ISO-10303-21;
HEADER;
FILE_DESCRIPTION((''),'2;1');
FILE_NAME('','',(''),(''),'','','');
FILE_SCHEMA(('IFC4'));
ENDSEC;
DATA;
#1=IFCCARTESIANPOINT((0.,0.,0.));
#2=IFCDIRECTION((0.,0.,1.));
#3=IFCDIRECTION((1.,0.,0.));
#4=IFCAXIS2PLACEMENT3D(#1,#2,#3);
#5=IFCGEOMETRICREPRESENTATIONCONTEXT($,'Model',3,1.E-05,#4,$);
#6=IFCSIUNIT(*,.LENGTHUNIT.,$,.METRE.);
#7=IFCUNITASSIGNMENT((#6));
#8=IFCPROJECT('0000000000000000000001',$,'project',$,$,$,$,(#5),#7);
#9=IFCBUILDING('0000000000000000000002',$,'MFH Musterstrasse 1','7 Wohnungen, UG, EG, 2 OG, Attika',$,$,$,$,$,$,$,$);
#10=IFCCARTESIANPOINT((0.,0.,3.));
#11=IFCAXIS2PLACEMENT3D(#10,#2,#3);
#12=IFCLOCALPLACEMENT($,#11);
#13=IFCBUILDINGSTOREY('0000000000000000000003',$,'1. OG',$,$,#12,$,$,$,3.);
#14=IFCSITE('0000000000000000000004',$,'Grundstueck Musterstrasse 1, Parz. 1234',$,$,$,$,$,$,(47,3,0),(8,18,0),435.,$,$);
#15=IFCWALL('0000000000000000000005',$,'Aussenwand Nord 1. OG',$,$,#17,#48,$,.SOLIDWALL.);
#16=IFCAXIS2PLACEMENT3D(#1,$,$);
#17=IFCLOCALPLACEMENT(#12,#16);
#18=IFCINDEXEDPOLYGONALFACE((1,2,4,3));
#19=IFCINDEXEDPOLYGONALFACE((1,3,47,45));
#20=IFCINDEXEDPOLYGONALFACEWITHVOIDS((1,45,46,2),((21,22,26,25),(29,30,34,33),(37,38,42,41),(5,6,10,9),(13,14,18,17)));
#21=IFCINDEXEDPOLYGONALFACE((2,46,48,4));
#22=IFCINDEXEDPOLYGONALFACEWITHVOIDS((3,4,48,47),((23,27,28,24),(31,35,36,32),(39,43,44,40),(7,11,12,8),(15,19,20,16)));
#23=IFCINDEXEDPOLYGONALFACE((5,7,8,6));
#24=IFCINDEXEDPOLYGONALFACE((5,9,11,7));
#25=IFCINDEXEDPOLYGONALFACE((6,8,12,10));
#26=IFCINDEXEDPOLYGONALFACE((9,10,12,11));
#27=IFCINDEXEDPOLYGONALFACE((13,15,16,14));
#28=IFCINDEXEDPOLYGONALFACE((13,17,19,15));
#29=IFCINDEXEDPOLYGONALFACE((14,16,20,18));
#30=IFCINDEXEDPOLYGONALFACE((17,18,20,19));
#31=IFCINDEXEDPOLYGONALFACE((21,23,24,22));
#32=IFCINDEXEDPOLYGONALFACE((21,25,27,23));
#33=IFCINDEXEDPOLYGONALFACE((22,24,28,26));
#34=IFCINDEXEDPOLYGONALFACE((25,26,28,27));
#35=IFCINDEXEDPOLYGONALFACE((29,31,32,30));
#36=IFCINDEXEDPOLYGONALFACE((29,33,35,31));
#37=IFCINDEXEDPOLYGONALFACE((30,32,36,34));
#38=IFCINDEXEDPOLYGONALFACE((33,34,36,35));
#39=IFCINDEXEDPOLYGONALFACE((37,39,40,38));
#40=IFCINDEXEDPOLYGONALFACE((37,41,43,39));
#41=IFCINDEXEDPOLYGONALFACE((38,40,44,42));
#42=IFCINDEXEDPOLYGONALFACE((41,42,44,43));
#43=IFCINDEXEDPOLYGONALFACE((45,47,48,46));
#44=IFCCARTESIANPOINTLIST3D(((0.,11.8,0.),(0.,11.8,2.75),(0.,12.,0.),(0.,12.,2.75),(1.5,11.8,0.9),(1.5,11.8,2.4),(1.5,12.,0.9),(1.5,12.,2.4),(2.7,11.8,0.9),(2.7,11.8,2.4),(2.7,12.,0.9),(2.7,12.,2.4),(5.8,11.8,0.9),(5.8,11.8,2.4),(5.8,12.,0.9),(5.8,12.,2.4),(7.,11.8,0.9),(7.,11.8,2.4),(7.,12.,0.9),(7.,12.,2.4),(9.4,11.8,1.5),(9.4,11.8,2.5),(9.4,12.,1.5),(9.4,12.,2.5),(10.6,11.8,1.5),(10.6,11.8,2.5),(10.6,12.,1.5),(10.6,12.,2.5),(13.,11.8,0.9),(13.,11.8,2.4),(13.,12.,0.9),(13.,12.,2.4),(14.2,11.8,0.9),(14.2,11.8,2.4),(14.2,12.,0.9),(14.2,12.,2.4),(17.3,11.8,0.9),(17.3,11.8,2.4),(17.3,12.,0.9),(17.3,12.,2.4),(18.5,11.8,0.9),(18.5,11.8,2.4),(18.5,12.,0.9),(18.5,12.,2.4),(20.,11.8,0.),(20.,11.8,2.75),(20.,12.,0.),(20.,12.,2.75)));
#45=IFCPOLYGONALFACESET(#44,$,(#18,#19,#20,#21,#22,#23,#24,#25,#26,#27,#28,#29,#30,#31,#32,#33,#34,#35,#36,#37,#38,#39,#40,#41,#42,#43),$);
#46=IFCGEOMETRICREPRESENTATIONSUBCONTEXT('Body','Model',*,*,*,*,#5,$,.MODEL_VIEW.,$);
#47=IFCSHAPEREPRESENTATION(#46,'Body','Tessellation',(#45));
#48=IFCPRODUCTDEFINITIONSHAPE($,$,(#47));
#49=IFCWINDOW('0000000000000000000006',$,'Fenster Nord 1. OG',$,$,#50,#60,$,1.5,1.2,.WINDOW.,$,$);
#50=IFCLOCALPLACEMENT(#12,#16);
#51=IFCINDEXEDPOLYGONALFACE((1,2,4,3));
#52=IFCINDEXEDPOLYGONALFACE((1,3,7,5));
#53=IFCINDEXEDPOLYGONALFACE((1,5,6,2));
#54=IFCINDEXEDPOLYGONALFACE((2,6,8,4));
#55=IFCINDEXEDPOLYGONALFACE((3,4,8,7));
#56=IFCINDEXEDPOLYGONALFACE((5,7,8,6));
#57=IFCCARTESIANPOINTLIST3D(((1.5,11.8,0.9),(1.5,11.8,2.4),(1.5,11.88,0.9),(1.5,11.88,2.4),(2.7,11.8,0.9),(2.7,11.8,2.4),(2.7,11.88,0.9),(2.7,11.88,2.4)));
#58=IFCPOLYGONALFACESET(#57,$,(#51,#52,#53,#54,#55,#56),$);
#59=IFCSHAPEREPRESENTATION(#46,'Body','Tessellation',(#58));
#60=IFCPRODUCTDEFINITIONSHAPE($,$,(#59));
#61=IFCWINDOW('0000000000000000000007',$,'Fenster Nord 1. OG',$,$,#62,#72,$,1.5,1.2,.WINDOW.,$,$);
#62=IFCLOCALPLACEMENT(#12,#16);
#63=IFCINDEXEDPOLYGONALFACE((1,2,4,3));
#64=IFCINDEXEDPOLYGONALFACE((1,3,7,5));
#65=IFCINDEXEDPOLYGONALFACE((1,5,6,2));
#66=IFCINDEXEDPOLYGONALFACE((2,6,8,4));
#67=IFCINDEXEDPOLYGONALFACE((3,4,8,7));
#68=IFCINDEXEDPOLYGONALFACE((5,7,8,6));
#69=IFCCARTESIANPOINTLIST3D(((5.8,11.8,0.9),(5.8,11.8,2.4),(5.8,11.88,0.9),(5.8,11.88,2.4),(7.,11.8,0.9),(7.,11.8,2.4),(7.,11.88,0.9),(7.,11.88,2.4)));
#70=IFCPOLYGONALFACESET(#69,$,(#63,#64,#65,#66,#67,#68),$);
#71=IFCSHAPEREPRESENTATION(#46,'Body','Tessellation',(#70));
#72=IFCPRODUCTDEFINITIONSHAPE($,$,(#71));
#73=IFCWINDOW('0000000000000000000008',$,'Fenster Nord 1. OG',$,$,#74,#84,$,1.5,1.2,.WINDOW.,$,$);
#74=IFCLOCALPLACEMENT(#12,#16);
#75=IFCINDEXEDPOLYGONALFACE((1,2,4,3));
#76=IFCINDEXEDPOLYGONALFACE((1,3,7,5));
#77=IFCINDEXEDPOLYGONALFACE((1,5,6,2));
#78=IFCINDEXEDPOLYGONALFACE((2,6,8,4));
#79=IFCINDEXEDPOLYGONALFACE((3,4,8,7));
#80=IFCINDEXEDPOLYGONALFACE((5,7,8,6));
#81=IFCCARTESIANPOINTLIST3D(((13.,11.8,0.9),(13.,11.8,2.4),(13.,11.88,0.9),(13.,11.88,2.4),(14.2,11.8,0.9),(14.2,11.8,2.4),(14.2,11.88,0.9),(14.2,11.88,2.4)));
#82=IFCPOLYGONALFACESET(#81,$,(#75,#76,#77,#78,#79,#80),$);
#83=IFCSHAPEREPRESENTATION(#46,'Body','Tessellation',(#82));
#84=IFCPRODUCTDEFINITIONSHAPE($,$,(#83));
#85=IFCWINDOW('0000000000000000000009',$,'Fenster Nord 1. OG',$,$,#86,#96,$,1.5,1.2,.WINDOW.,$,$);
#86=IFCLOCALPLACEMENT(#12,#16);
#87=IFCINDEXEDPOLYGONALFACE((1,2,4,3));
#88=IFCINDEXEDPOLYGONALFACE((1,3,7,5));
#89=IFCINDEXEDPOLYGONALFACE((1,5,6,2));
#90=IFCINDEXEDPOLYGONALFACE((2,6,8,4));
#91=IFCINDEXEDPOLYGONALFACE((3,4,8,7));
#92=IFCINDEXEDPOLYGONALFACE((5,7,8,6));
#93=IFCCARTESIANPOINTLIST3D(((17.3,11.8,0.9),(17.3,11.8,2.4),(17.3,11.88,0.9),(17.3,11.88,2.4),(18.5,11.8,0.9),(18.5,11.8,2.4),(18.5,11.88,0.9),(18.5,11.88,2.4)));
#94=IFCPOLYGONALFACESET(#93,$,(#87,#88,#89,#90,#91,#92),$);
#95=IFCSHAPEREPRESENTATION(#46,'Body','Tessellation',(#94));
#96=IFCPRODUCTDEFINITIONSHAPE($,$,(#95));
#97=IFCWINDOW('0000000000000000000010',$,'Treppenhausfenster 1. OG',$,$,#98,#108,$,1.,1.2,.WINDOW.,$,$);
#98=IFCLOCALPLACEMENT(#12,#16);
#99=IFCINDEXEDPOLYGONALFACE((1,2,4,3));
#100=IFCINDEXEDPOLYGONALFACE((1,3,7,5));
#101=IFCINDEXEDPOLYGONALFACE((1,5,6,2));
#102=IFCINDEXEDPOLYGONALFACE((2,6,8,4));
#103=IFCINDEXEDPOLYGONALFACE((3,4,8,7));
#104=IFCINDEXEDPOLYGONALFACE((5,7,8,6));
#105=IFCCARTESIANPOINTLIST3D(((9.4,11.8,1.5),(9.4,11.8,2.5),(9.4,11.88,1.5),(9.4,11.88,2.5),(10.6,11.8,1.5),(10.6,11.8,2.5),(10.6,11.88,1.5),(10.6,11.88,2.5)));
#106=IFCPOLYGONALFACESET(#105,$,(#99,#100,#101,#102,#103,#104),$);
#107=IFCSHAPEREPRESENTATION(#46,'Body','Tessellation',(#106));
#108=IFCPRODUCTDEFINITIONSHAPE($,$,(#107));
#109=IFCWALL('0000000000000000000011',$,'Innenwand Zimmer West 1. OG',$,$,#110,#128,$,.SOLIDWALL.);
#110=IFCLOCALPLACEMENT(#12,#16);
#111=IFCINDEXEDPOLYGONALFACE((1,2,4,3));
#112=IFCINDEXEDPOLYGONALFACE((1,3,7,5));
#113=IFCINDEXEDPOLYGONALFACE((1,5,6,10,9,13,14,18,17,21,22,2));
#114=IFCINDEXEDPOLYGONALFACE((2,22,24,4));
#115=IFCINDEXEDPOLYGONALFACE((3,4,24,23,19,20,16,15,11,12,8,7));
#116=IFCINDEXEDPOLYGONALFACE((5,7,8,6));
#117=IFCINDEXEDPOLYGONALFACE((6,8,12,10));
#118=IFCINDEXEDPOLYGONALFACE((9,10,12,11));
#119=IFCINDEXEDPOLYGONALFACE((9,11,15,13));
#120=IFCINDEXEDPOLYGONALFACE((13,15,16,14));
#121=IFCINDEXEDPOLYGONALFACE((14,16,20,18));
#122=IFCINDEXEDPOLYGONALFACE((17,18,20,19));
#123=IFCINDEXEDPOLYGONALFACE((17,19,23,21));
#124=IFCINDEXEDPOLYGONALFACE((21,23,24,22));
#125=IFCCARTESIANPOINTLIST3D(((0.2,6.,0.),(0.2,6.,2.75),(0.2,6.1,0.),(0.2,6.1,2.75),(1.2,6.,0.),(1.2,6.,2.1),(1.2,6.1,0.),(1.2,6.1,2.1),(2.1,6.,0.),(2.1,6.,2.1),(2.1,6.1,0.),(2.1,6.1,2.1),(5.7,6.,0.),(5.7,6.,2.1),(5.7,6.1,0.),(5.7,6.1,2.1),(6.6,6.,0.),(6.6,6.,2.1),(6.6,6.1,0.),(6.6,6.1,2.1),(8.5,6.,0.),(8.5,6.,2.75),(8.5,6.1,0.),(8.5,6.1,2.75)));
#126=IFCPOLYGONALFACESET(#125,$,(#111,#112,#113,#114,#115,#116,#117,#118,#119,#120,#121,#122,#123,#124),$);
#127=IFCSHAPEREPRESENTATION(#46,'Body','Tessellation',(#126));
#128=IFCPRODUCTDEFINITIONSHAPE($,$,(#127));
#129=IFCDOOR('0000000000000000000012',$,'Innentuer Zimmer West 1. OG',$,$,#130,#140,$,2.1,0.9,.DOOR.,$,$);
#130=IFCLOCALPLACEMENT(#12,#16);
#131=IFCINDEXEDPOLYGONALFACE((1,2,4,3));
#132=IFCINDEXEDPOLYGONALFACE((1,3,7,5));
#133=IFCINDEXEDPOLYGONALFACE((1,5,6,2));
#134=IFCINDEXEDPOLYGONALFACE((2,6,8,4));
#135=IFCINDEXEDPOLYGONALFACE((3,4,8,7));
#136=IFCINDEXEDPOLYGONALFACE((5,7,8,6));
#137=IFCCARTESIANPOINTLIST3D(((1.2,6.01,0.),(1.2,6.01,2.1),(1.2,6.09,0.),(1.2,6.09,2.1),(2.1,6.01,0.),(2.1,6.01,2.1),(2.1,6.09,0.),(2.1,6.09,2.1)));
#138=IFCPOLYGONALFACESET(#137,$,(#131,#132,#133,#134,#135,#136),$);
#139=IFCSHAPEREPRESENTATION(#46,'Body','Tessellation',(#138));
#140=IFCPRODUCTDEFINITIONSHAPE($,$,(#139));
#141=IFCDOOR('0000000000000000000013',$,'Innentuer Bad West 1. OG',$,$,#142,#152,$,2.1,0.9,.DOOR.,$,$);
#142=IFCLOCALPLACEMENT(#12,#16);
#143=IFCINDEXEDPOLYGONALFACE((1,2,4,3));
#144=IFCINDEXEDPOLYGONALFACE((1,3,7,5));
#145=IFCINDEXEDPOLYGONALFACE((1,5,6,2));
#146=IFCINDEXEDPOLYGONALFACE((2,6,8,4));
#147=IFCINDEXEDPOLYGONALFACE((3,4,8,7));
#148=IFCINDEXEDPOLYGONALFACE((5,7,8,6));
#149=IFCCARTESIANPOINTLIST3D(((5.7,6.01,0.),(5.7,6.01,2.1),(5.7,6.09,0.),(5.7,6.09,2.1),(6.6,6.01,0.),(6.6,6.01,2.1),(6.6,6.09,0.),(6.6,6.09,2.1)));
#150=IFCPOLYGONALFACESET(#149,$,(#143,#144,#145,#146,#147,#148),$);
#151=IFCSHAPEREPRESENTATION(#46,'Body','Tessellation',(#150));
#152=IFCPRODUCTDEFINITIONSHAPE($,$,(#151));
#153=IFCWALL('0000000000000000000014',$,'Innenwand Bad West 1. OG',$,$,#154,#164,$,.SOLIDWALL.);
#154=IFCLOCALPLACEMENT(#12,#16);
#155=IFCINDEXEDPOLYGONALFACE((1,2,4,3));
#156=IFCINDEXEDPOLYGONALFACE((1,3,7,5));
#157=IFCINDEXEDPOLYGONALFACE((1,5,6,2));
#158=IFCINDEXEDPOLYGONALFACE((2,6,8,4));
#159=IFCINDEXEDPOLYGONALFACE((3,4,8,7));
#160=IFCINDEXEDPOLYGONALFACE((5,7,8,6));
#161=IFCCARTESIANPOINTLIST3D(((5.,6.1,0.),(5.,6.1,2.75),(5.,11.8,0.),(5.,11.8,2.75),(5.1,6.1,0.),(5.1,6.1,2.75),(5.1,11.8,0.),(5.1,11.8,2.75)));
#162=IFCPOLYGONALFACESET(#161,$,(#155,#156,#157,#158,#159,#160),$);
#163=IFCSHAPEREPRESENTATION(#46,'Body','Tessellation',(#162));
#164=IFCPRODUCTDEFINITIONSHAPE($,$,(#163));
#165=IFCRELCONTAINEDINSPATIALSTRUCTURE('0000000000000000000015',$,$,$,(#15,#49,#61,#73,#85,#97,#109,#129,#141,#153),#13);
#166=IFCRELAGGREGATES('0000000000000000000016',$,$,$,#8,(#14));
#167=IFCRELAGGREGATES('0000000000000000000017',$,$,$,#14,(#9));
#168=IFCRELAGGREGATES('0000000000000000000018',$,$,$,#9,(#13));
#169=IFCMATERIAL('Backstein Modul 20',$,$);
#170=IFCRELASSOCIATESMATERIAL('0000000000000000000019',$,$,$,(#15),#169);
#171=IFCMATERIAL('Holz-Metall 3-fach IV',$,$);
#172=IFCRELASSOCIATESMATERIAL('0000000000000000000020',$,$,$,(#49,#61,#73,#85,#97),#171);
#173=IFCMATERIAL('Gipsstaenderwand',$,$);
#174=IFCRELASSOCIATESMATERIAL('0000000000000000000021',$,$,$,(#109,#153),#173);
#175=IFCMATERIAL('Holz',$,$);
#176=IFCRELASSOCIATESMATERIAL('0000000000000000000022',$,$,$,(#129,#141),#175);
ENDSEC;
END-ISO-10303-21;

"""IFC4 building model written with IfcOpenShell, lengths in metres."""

from ifc_helpers import new_model, si_unit, frame, frame_2d, origin_with_axes, place, context, subcontext, project, spatial, rectangle, extrude, material, element, fill, save


model = new_model("IFC4")

# Units and contexts
model_context = context("Model", 3, precision=1e-05, world=origin_with_axes())
body_context = subcontext(model_context, "Body", "Model", "MODEL_VIEW")
ifc_project = project(units=[si_unit("LENGTHUNIT", "METRE")], contexts=[model_context])

# Site, building, storey
site = spatial("IfcSite", under=ifc_project, Name="Grundstueck Musterstrasse 1, Parz. 1234", RefLatitude=(47, 3, 0), RefLongitude=(8, 18, 0), RefElevation=435.0)
building = spatial("IfcBuilding", under=site, Name="MFH Musterstrasse 1", Description="7 Wohnungen, UG, EG, 2 OG, Attika")
storey_placement = place(None, frame((0.0, 0.0, 3.0), z_axis=(0.0, 0.0, 1.0), x_axis=(1.0, 0.0, 0.0)))
storey = spatial("IfcBuildingStorey", under=building, at=storey_placement, Name="1. OG", Elevation=3.0)

# Wall, openings, windows
ifc_material_1 = material(Name="Backstein Modul 20")
wall_1_placement = place(storey_placement, frame((0.0, 11.8, 0.0), z_axis=(0.0, 0.0, 1.0), x_axis=(1.0, 0.0, 0.0)))
wall_1 = element("IfcWall", 1, at=wall_1_placement, inside=storey, material=ifc_material_1, Name="Aussenwand Nord 1. OG", PredefinedType="SOLIDWALL", context=body_context, shape_type="SweptSolid", body=[
    extrude(rectangle(XDim=20.0, YDim=0.2, at=frame_2d((10.0, 0.1))), origin_with_axes(), (0.0, 0.0, 1.0), 2.75),
])
opening_1_placement = place(wall_1_placement, frame((1.5, -0.01, 0.9), z_axis=(0.0, 0.0, 1.0), x_axis=(1.0, 0.0, 0.0)))
opening_1 = element("IfcOpeningElement", 2, at=opening_1_placement, cuts=wall_1, context=body_context, shape_type="SweptSolid", body=[
    extrude(rectangle(XDim=1.2, YDim=0.42, at=frame_2d((0.6, 0.21))), origin_with_axes(), (0.0, 0.0, 1.0), 1.5),
])
opening_2_placement = place(wall_1_placement, frame((5.8, -0.01, 0.9), z_axis=(0.0, 0.0, 1.0), x_axis=(1.0, 0.0, 0.0)))
opening_2 = element("IfcOpeningElement", 3, at=opening_2_placement, cuts=wall_1, context=body_context, shape_type="SweptSolid", body=[
    extrude(rectangle(XDim=1.2, YDim=0.42, at=frame_2d((0.6, 0.21))), origin_with_axes(), (0.0, 0.0, 1.0), 1.5),
])
opening_3_placement = place(wall_1_placement, frame((13.0, -0.01, 0.9), z_axis=(0.0, 0.0, 1.0), x_axis=(1.0, 0.0, 0.0)))
opening_3 = element("IfcOpeningElement", 4, at=opening_3_placement, cuts=wall_1, context=body_context, shape_type="SweptSolid", body=[
    extrude(rectangle(XDim=1.2, YDim=0.42, at=frame_2d((0.6, 0.21))), origin_with_axes(), (0.0, 0.0, 1.0), 1.5),
])
opening_4_placement = place(wall_1_placement, frame((17.3, -0.01, 0.9), z_axis=(0.0, 0.0, 1.0), x_axis=(1.0, 0.0, 0.0)))
opening_4 = element("IfcOpeningElement", 5, at=opening_4_placement, cuts=wall_1, context=body_context, shape_type="SweptSolid", body=[
    extrude(rectangle(XDim=1.2, YDim=0.42, at=frame_2d((0.6, 0.21))), origin_with_axes(), (0.0, 0.0, 1.0), 1.5),
])
opening_5_placement = place(wall_1_placement, frame((9.4, -0.01, 1.5), z_axis=(0.0, 0.0, 1.0), x_axis=(1.0, 0.0, 0.0)))
opening_5 = element("IfcOpeningElement", 6, at=opening_5_placement, cuts=wall_1, context=body_context, shape_type="SweptSolid", body=[
    extrude(rectangle(XDim=1.2, YDim=0.42, at=frame_2d((0.6, 0.21))), origin_with_axes(), (0.0, 0.0, 1.0), 1.0),
])
ifc_material_2 = material(Name="Holz-Metall 3-fach IV")
window_1_placement = place(storey_placement, frame((1.5, 11.8, 0.9), z_axis=(0.0, 0.0, 1.0), x_axis=(1.0, 0.0, 0.0)))
window_1 = element("IfcWindow", 7, at=window_1_placement, inside=storey, material=ifc_material_2, Name="Fenster Nord 1. OG", OverallHeight=1.5, OverallWidth=1.2, PredefinedType="WINDOW", context=body_context, shape_type="SweptSolid", body=[
    extrude(rectangle(XDim=1.2, YDim=0.08, at=frame_2d((0.6, 0.04))), origin_with_axes(), (0.0, 0.0, 1.0), 1.5),
])
fill(opening_1, window_1)
window_2_placement = place(storey_placement, frame((5.8, 11.8, 0.9), z_axis=(0.0, 0.0, 1.0), x_axis=(1.0, 0.0, 0.0)))
window_2 = element("IfcWindow", 8, at=window_2_placement, inside=storey, material=ifc_material_2, Name="Fenster Nord 1. OG", OverallHeight=1.5, OverallWidth=1.2, PredefinedType="WINDOW", context=body_context, shape_type="SweptSolid", body=[
    extrude(rectangle(XDim=1.2, YDim=0.08, at=frame_2d((0.6, 0.04))), origin_with_axes(), (0.0, 0.0, 1.0), 1.5),
])
fill(opening_2, window_2)
window_3_placement = place(storey_placement, frame((13.0, 11.8, 0.9), z_axis=(0.0, 0.0, 1.0), x_axis=(1.0, 0.0, 0.0)))
window_3 = element("IfcWindow", 9, at=window_3_placement, inside=storey, material=ifc_material_2, Name="Fenster Nord 1. OG", OverallHeight=1.5, OverallWidth=1.2, PredefinedType="WINDOW", context=body_context, shape_type="SweptSolid", body=[
    extrude(rectangle(XDim=1.2, YDim=0.08, at=frame_2d((0.6, 0.04))), origin_with_axes(), (0.0, 0.0, 1.0), 1.5),
])
fill(opening_3, window_3)
window_4_placement = place(storey_placement, frame((17.3, 11.8, 0.9), z_axis=(0.0, 0.0, 1.0), x_axis=(1.0, 0.0, 0.0)))
window_4 = element("IfcWindow", 10, at=window_4_placement, inside=storey, material=ifc_material_2, Name="Fenster Nord 1. OG", OverallHeight=1.5, OverallWidth=1.2, PredefinedType="WINDOW", context=body_context, shape_type="SweptSolid", body=[
    extrude(rectangle(XDim=1.2, YDim=0.08, at=frame_2d((0.6, 0.04))), origin_with_axes(), (0.0, 0.0, 1.0), 1.5),
])
fill(opening_4, window_4)
window_5_placement = place(storey_placement, frame((9.4, 11.8, 1.5), z_axis=(0.0, 0.0, 1.0), x_axis=(1.0, 0.0, 0.0)))
window_5 = element("IfcWindow", 11, at=window_5_placement, inside=storey, material=ifc_material_2, Name="Treppenhausfenster 1. OG", OverallHeight=1.0, OverallWidth=1.2, PredefinedType="WINDOW", context=body_context, shape_type="SweptSolid", body=[
    extrude(rectangle(XDim=1.2, YDim=0.08, at=frame_2d((0.6, 0.04))), origin_with_axes(), (0.0, 0.0, 1.0), 1.0),
])
fill(opening_5, window_5)

# Wall, openings, doors
ifc_material_3 = material(Name="Gipsstaenderwand")
wall_2_placement = place(storey_placement, frame((0.2, 6.0, 0.0), z_axis=(0.0, 0.0, 1.0), x_axis=(1.0, 0.0, 0.0)))
wall_2 = element("IfcWall", 12, at=wall_2_placement, inside=storey, material=ifc_material_3, Name="Innenwand Zimmer West 1. OG", PredefinedType="SOLIDWALL", context=body_context, shape_type="SweptSolid", body=[
    extrude(rectangle(XDim=8.3, YDim=0.1, at=frame_2d((4.15, 0.05))), origin_with_axes(), (0.0, 0.0, 1.0), 2.75),
])
opening_6_placement = place(wall_2_placement, frame((1.0, -0.01, 0.0), z_axis=(0.0, 0.0, 1.0), x_axis=(1.0, 0.0, 0.0)))
opening_6 = element("IfcOpeningElement", 13, at=opening_6_placement, cuts=wall_2, context=body_context, shape_type="SweptSolid", body=[
    extrude(rectangle(XDim=0.9, YDim=0.12, at=frame_2d((0.45, 0.06))), origin_with_axes(), (0.0, 0.0, 1.0), 2.1),
])
opening_7_placement = place(wall_2_placement, frame((5.5, -0.01, 0.0), z_axis=(0.0, 0.0, 1.0), x_axis=(1.0, 0.0, 0.0)))
opening_7 = element("IfcOpeningElement", 14, at=opening_7_placement, cuts=wall_2, context=body_context, shape_type="SweptSolid", body=[
    extrude(rectangle(XDim=0.9, YDim=0.12, at=frame_2d((0.45, 0.06))), origin_with_axes(), (0.0, 0.0, 1.0), 2.1),
])
ifc_material_4 = material(Name="Holz")
door_1_placement = place(storey_placement, frame((1.2, 6.01, 0.0), z_axis=(0.0, 0.0, 1.0), x_axis=(1.0, 0.0, 0.0)))
door_1 = element("IfcDoor", 15, at=door_1_placement, inside=storey, material=ifc_material_4, Name="Innentuer Zimmer West 1. OG", OverallHeight=2.1, OverallWidth=0.9, PredefinedType="DOOR", context=body_context, shape_type="SweptSolid", body=[
    extrude(rectangle(XDim=0.9, YDim=0.08, at=frame_2d((0.45, 0.04))), origin_with_axes(), (0.0, 0.0, 1.0), 2.1),
])
fill(opening_6, door_1)
door_2_placement = place(storey_placement, frame((5.7, 6.01, 0.0), z_axis=(0.0, 0.0, 1.0), x_axis=(1.0, 0.0, 0.0)))
door_2 = element("IfcDoor", 16, at=door_2_placement, inside=storey, material=ifc_material_4, Name="Innentuer Bad West 1. OG", OverallHeight=2.1, OverallWidth=0.9, PredefinedType="DOOR", context=body_context, shape_type="SweptSolid", body=[
    extrude(rectangle(XDim=0.9, YDim=0.08, at=frame_2d((0.45, 0.04))), origin_with_axes(), (0.0, 0.0, 1.0), 2.1),
])
fill(opening_7, door_2)

# Wall
wall_3_placement = place(storey_placement, frame((5.0, 6.1, 0.0), z_axis=(0.0, 0.0, 1.0), x_axis=(1.0, 0.0, 0.0)))
element("IfcWall", 17, at=wall_3_placement, inside=storey, material=ifc_material_3, Name="Innenwand Bad West 1. OG", PredefinedType="SOLIDWALL", context=body_context, shape_type="SweptSolid", body=[
    extrude(rectangle(XDim=0.1, YDim=5.7, at=frame_2d((0.05, 2.85))), origin_with_axes(), (0.0, 0.0, 1.0), 2.75),
])

save(model, "model.ifc")
